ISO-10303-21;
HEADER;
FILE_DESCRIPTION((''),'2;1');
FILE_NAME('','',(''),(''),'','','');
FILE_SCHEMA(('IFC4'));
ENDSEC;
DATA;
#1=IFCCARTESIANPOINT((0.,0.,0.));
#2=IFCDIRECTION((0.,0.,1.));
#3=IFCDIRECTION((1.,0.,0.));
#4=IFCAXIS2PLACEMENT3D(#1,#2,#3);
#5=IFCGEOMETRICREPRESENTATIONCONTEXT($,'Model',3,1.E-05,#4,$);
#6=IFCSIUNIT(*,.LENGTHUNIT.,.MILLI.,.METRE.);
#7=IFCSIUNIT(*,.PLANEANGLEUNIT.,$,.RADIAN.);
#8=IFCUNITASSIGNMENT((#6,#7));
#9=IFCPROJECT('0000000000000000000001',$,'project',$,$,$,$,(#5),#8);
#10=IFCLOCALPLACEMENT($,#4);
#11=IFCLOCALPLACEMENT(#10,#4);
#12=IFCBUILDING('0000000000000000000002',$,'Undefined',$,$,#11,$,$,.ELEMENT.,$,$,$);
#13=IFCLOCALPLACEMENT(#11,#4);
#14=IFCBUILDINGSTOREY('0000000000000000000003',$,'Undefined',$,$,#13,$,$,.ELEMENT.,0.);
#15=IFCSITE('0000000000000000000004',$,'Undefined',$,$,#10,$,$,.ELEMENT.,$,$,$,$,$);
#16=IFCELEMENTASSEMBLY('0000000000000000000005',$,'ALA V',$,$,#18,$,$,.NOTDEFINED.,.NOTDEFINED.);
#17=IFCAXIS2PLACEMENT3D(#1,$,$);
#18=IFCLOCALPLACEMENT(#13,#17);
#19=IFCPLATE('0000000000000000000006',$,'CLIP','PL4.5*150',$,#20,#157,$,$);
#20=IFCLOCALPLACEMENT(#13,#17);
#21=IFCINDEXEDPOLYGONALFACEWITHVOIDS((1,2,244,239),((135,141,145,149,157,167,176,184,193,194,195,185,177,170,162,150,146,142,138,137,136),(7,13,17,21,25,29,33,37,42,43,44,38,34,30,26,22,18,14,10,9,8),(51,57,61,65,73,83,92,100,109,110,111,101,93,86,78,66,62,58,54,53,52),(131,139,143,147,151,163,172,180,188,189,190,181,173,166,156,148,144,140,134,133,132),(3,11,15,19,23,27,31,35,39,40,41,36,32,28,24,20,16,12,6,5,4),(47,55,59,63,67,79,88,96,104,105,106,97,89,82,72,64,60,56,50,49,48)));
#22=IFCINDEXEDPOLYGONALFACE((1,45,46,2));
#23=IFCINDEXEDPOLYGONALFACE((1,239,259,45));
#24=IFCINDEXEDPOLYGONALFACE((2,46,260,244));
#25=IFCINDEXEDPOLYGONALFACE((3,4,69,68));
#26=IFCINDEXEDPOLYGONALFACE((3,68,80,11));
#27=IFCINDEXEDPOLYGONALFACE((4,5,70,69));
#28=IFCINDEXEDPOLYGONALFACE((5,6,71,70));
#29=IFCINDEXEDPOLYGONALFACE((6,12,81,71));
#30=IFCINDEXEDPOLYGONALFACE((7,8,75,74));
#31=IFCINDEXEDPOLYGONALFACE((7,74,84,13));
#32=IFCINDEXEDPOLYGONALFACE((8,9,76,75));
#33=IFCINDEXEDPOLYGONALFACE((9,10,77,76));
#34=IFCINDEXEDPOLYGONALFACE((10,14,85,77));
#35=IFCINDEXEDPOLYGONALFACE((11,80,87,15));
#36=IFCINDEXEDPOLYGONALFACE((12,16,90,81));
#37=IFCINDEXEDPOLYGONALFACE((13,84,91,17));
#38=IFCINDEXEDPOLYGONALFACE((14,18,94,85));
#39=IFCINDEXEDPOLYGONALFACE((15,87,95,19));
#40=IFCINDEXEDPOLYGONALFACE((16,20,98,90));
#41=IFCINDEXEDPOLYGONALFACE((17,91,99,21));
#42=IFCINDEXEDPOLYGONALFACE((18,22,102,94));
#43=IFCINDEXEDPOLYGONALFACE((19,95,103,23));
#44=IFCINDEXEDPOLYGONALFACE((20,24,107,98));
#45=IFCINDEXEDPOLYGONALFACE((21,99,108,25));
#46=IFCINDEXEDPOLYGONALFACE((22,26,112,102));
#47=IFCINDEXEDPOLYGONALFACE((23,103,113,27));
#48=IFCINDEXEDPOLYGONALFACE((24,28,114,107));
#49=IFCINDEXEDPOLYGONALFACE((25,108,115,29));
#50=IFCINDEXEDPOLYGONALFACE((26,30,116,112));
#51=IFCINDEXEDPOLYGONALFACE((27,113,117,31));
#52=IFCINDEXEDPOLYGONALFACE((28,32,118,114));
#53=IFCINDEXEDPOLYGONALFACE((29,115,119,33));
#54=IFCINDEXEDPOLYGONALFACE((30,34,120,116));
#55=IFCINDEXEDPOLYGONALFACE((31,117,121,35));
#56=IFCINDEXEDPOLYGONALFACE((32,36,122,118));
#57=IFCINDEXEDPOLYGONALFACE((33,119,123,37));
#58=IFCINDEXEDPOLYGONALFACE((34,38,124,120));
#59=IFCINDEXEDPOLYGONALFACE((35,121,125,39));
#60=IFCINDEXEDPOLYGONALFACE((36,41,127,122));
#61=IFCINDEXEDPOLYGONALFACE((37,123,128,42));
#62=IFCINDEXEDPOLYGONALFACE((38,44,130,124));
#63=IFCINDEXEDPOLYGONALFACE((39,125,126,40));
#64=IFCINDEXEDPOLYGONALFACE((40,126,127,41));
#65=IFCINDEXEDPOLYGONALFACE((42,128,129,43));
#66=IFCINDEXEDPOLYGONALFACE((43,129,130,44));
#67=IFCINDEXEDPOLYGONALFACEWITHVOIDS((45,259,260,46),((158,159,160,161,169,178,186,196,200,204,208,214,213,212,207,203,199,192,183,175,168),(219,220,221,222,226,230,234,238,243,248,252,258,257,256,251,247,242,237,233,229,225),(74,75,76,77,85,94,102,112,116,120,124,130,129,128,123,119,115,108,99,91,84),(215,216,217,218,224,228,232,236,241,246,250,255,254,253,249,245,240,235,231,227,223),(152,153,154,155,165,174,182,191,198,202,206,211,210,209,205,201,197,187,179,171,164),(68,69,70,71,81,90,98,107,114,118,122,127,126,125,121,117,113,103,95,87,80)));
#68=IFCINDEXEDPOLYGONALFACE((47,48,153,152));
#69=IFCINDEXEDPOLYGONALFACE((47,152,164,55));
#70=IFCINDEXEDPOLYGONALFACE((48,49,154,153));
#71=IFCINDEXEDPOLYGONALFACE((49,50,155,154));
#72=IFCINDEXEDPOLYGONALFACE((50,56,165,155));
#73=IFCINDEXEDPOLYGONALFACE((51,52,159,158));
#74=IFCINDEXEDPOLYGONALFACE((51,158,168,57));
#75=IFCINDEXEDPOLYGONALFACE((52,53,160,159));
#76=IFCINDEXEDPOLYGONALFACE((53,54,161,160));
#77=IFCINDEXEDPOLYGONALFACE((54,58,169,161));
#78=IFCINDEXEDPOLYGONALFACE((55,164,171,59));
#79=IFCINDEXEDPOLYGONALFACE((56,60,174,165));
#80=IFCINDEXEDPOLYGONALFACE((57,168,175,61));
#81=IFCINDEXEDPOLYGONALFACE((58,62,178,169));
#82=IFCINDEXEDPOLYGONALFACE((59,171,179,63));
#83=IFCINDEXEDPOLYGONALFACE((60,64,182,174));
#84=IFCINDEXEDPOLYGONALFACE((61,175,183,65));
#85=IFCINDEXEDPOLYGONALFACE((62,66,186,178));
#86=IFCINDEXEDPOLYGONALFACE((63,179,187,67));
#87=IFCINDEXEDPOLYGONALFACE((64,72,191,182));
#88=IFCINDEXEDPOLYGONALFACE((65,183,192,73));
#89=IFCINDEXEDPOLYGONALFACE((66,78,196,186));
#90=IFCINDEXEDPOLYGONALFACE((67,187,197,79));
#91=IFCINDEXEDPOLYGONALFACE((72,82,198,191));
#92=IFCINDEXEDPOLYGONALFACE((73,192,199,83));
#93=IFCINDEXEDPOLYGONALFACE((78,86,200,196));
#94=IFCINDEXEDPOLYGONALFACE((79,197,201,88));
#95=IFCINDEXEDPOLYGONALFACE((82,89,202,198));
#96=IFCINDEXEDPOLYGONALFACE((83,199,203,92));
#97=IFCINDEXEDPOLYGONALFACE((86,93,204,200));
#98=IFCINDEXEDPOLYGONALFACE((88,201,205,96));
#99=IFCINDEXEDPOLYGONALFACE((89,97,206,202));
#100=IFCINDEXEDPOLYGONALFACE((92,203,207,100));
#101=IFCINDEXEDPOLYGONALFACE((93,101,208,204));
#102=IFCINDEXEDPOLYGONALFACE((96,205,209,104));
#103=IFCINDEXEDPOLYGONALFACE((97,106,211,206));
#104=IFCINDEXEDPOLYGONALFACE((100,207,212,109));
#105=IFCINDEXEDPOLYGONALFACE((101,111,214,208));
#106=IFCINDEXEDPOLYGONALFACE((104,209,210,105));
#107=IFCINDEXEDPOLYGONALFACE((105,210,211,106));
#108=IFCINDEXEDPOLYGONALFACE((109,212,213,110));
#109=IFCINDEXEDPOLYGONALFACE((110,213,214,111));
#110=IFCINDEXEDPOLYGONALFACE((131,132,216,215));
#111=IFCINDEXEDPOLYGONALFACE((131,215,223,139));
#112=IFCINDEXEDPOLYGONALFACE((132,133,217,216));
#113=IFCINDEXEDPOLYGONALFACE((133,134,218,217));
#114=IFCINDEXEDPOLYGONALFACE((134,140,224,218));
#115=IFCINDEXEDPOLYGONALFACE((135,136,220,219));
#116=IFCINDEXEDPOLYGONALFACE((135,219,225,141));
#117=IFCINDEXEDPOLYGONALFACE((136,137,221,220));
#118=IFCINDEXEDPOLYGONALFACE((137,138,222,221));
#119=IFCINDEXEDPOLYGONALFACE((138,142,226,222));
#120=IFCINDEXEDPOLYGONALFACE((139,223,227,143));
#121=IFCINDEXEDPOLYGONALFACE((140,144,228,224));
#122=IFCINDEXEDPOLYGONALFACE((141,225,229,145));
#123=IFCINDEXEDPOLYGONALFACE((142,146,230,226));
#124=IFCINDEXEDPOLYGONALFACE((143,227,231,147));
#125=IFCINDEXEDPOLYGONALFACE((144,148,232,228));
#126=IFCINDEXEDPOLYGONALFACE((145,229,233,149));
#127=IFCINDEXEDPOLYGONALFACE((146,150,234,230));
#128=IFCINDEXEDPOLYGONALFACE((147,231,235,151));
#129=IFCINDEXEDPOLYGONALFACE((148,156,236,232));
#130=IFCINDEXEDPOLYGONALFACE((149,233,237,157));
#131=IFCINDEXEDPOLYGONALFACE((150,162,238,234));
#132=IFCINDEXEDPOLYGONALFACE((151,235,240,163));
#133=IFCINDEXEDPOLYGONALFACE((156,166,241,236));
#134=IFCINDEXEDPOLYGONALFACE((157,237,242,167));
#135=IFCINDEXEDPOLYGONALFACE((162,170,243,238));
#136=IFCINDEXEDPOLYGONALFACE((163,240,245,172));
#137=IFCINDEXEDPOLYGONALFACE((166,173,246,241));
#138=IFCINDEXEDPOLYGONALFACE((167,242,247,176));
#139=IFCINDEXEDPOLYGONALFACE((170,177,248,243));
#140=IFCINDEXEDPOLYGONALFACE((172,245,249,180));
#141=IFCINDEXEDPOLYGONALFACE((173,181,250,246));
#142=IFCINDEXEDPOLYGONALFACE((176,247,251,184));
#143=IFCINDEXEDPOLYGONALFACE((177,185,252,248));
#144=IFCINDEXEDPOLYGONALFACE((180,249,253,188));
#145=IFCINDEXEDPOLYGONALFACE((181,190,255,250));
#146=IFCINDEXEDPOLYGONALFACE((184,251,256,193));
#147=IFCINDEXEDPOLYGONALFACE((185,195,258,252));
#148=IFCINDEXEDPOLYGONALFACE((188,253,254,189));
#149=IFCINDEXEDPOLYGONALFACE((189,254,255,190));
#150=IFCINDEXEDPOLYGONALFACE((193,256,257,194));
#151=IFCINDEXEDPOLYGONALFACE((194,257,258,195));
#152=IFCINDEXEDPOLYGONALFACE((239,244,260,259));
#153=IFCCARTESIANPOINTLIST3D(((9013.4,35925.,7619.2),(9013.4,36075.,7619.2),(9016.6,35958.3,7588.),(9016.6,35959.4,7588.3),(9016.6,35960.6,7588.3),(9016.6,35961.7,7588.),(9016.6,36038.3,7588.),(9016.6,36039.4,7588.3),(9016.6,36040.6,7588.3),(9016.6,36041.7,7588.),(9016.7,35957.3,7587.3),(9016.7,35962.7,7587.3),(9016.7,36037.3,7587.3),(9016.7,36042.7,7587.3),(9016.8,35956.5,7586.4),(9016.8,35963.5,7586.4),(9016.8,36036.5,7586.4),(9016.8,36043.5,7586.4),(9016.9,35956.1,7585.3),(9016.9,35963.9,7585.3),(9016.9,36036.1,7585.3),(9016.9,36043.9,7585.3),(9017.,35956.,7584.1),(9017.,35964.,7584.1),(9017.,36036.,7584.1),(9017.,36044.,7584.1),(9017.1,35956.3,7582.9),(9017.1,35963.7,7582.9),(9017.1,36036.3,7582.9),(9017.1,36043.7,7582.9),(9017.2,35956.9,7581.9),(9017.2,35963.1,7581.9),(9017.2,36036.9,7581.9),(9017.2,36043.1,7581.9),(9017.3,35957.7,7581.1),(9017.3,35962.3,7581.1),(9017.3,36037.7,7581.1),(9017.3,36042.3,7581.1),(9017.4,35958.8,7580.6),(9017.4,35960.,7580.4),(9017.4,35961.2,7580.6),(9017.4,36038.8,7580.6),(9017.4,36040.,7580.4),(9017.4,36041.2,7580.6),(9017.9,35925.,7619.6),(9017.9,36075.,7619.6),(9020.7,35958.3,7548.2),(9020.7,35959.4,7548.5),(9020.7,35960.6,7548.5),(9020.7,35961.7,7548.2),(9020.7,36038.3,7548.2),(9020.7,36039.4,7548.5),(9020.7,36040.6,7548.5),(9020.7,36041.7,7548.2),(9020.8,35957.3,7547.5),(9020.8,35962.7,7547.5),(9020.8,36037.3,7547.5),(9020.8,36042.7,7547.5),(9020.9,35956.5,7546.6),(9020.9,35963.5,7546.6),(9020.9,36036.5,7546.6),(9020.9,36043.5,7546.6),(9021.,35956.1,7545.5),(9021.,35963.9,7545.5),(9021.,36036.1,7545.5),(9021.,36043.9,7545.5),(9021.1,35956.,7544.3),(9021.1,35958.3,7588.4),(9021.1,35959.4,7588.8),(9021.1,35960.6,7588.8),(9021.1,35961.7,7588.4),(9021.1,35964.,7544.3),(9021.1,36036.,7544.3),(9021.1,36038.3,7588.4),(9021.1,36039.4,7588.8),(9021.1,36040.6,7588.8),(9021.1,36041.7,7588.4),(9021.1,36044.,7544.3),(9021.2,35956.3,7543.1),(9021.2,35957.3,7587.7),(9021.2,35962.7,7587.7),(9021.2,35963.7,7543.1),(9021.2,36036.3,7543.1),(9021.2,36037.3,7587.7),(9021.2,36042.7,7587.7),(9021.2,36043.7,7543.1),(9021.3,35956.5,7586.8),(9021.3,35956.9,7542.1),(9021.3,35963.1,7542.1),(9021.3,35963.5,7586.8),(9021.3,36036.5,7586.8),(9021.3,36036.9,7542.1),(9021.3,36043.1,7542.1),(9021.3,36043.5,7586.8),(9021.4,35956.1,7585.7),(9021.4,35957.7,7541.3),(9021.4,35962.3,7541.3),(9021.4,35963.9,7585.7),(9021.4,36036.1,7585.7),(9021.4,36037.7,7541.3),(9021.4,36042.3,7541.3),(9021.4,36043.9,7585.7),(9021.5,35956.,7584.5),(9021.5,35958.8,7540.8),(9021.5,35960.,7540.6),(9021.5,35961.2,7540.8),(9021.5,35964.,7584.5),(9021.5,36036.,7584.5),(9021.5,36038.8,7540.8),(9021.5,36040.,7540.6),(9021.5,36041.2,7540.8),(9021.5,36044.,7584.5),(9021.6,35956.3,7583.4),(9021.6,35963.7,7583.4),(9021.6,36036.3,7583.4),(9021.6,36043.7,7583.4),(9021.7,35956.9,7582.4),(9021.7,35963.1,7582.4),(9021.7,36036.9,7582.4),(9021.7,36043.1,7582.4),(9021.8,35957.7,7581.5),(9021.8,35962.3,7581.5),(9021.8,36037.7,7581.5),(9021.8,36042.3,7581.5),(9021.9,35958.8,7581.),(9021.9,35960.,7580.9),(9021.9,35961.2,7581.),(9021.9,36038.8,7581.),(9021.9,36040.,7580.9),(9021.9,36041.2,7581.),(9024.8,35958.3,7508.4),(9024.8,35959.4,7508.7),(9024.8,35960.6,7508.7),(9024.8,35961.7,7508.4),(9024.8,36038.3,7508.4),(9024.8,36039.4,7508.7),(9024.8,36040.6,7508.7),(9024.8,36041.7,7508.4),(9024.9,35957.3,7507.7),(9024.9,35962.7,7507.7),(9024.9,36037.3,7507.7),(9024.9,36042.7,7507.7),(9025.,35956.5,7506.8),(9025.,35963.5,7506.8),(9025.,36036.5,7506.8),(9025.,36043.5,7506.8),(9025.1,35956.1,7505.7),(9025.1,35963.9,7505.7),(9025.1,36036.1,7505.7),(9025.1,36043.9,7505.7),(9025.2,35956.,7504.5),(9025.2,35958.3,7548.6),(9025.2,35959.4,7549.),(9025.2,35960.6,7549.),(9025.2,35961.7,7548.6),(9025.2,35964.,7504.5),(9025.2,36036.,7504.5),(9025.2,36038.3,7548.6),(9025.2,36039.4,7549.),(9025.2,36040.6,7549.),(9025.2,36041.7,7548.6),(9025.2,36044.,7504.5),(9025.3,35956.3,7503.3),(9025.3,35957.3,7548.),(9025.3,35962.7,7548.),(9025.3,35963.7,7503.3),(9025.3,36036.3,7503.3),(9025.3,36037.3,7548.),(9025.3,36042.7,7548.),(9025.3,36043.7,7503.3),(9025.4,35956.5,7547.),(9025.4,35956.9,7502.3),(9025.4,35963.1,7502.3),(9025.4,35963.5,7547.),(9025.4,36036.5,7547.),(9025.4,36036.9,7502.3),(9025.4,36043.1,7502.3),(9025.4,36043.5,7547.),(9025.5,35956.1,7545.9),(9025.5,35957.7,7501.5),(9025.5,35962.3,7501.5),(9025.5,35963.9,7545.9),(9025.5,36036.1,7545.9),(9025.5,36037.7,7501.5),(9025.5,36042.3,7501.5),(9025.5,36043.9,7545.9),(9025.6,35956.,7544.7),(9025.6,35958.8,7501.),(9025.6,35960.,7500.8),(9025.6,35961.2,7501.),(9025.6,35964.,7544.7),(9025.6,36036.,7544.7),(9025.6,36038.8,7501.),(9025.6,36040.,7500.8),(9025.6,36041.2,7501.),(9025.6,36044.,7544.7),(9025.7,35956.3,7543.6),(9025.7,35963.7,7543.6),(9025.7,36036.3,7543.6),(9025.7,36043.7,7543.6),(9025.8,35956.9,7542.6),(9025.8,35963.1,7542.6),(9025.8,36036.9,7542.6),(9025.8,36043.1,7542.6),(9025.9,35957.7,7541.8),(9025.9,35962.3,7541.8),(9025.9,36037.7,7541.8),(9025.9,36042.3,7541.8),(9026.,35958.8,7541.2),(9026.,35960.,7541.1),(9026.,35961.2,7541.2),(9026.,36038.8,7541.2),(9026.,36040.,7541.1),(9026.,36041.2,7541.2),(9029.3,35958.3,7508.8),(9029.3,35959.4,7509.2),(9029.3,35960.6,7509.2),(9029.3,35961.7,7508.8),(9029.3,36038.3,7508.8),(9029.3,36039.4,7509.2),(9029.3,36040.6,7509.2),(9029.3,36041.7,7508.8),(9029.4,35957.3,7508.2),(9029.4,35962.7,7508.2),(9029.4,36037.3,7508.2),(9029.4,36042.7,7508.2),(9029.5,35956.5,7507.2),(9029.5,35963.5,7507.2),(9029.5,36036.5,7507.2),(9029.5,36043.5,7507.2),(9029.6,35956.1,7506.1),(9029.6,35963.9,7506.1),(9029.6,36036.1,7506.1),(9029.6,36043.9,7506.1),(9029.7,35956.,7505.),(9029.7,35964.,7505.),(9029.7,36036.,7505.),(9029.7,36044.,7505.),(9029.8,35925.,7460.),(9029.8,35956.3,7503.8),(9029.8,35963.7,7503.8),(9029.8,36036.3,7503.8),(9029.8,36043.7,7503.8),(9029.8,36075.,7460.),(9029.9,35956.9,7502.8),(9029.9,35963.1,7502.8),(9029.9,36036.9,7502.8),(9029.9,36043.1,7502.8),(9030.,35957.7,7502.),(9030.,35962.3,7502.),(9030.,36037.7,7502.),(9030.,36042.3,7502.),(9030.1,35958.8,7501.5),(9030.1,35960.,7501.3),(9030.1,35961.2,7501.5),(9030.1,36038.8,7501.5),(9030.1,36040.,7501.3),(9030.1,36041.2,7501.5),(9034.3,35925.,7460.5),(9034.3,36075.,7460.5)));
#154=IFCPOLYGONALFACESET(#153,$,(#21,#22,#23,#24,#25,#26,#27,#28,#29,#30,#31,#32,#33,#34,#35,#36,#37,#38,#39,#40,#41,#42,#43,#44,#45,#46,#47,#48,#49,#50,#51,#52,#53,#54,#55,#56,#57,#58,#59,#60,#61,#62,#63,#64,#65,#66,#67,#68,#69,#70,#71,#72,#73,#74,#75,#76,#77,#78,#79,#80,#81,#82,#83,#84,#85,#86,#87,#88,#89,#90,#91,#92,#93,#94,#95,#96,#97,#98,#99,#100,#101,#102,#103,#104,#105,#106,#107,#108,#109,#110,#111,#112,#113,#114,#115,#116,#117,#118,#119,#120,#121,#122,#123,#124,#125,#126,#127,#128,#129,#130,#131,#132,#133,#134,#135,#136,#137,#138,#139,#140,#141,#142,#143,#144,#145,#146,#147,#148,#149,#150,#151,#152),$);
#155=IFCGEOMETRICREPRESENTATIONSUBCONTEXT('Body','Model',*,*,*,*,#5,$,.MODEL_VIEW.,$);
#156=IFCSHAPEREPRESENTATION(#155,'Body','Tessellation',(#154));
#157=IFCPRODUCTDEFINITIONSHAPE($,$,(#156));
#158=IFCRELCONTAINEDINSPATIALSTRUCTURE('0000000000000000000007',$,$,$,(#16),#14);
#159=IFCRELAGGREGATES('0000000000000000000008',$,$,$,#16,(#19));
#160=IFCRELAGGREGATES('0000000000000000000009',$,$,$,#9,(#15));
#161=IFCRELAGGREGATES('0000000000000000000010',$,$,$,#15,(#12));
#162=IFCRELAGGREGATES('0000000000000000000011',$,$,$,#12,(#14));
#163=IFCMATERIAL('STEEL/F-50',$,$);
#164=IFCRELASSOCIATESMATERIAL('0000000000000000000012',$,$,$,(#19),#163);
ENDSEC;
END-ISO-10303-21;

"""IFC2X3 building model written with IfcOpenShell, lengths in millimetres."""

from ifc_helpers import new_model, si_unit, frame, origin_with_axes, origin_2d_with_axis, place, context, subcontext, project, spatial, polyline, circle, outline, extrude, source, transform, mapped, material, element, aggregate, save


model = new_model("IFC2X3")

# Units and contexts
model_context = context("Model", 3, precision=1e-05, world=origin_with_axes())
body_context = subcontext(model_context, "Body", "Model", "MODEL_VIEW")
ifc_project = project(units=[si_unit("LENGTHUNIT", "METRE", prefix="MILLI"), si_unit("PLANEANGLEUNIT", "RADIAN")], contexts=[model_context])

# Site, building, storey
site_placement = place(None, origin_with_axes())
site = spatial("IfcSite", under=ifc_project, at=site_placement, Name="Undefined", CompositionType="ELEMENT")
building_placement = place(site_placement, origin_with_axes())
building = spatial("IfcBuilding", under=site, at=building_placement, Name="Undefined", CompositionType="ELEMENT")
storey_placement = place(building_placement, origin_with_axes())
storey = spatial("IfcBuildingStorey", under=building, at=storey_placement, Name="Undefined", CompositionType="ELEMENT", Elevation=0.0)

# Element assembly
assembly_1_placement = place(storey_placement, origin_with_axes())
assembly_1 = element("IfcElementAssembly", 1, at=assembly_1_placement, inside=storey, Name="ALA V", AssemblyPlace="NOTDEFINED", PredefinedType="NOTDEFINED")
ifc_material_1 = material(Name="STEEL/F-50")

# Plate, openings
shared_shape_1 = source(origin_with_axes(), body_context, "Body", "SweptSolid", [
    extrude(circle(Radius=4.0, at=origin_2d_with_axis()), frame((0.0, -4.6, 0.0), z_axis=(0.0, 1.0, 0.0), x_axis=(1.0, 0.0, 0.0)), (0.0, 0.0, 1.0), 4.7),
])
plate_1_placement = place(assembly_1_placement, frame((9015.6, 35925.0, 7619.4), z_axis=(0.994727, 0.0, 0.102562), x_axis=(0.102562, 0.0, -0.994727)))
plate_1 = element("IfcPlate", 2, at=plate_1_placement, material=ifc_material_1, Name="CLIP", Description="PL4.5*150", context=body_context, shape_type="SweptSolid", body=[
    extrude(outline(polyline([(0.0, 0.0), (160.0, 0.0), (160.0, 150.0), (0.0, 150.0), (0.0, 0.0)])), frame((0.0, 0.0, -2.2), z_axis=(0.0, 0.0, 1.0), x_axis=(1.0, 0.0, 0.0)), (0.0, 0.0, 1.0), 4.5),
])
opening_1_placement = place(assembly_1_placement, frame((9017.0, 36040.0, 7584.4), z_axis=(0.0, 1.0, 0.0), x_axis=(0.102562, 0.0, -0.994727)))
element("IfcOpeningElement", 3, at=opening_1_placement, cuts=plate_1, ObjectType="Opening", context=body_context, shape_type="MappedRepresentation", body=[
    mapped(shared_shape_1, transform((0.0, 0.0, 0.0))),
    mapped(shared_shape_1, transform((40.0, 0.0, 0.0))),
    mapped(shared_shape_1, transform((80.0, 0.0, 0.0))),
])
opening_2_placement = place(assembly_1_placement, frame((9017.0, 35960.0, 7584.4), z_axis=(0.0, 1.0, 0.0), x_axis=(0.102562, 0.0, -0.994727)))
element("IfcOpeningElement", 4, at=opening_2_placement, cuts=plate_1, ObjectType="Opening", context=body_context, shape_type="MappedRepresentation", body=[
    mapped(shared_shape_1, transform((0.0, 0.0, 0.0))),
    mapped(shared_shape_1, transform((40.0, 0.0, 0.0))),
    mapped(shared_shape_1, transform((80.0, 0.0, 0.0))),
])

aggregate(assembly_1, [plate_1])

save(model, "model.ifc")
